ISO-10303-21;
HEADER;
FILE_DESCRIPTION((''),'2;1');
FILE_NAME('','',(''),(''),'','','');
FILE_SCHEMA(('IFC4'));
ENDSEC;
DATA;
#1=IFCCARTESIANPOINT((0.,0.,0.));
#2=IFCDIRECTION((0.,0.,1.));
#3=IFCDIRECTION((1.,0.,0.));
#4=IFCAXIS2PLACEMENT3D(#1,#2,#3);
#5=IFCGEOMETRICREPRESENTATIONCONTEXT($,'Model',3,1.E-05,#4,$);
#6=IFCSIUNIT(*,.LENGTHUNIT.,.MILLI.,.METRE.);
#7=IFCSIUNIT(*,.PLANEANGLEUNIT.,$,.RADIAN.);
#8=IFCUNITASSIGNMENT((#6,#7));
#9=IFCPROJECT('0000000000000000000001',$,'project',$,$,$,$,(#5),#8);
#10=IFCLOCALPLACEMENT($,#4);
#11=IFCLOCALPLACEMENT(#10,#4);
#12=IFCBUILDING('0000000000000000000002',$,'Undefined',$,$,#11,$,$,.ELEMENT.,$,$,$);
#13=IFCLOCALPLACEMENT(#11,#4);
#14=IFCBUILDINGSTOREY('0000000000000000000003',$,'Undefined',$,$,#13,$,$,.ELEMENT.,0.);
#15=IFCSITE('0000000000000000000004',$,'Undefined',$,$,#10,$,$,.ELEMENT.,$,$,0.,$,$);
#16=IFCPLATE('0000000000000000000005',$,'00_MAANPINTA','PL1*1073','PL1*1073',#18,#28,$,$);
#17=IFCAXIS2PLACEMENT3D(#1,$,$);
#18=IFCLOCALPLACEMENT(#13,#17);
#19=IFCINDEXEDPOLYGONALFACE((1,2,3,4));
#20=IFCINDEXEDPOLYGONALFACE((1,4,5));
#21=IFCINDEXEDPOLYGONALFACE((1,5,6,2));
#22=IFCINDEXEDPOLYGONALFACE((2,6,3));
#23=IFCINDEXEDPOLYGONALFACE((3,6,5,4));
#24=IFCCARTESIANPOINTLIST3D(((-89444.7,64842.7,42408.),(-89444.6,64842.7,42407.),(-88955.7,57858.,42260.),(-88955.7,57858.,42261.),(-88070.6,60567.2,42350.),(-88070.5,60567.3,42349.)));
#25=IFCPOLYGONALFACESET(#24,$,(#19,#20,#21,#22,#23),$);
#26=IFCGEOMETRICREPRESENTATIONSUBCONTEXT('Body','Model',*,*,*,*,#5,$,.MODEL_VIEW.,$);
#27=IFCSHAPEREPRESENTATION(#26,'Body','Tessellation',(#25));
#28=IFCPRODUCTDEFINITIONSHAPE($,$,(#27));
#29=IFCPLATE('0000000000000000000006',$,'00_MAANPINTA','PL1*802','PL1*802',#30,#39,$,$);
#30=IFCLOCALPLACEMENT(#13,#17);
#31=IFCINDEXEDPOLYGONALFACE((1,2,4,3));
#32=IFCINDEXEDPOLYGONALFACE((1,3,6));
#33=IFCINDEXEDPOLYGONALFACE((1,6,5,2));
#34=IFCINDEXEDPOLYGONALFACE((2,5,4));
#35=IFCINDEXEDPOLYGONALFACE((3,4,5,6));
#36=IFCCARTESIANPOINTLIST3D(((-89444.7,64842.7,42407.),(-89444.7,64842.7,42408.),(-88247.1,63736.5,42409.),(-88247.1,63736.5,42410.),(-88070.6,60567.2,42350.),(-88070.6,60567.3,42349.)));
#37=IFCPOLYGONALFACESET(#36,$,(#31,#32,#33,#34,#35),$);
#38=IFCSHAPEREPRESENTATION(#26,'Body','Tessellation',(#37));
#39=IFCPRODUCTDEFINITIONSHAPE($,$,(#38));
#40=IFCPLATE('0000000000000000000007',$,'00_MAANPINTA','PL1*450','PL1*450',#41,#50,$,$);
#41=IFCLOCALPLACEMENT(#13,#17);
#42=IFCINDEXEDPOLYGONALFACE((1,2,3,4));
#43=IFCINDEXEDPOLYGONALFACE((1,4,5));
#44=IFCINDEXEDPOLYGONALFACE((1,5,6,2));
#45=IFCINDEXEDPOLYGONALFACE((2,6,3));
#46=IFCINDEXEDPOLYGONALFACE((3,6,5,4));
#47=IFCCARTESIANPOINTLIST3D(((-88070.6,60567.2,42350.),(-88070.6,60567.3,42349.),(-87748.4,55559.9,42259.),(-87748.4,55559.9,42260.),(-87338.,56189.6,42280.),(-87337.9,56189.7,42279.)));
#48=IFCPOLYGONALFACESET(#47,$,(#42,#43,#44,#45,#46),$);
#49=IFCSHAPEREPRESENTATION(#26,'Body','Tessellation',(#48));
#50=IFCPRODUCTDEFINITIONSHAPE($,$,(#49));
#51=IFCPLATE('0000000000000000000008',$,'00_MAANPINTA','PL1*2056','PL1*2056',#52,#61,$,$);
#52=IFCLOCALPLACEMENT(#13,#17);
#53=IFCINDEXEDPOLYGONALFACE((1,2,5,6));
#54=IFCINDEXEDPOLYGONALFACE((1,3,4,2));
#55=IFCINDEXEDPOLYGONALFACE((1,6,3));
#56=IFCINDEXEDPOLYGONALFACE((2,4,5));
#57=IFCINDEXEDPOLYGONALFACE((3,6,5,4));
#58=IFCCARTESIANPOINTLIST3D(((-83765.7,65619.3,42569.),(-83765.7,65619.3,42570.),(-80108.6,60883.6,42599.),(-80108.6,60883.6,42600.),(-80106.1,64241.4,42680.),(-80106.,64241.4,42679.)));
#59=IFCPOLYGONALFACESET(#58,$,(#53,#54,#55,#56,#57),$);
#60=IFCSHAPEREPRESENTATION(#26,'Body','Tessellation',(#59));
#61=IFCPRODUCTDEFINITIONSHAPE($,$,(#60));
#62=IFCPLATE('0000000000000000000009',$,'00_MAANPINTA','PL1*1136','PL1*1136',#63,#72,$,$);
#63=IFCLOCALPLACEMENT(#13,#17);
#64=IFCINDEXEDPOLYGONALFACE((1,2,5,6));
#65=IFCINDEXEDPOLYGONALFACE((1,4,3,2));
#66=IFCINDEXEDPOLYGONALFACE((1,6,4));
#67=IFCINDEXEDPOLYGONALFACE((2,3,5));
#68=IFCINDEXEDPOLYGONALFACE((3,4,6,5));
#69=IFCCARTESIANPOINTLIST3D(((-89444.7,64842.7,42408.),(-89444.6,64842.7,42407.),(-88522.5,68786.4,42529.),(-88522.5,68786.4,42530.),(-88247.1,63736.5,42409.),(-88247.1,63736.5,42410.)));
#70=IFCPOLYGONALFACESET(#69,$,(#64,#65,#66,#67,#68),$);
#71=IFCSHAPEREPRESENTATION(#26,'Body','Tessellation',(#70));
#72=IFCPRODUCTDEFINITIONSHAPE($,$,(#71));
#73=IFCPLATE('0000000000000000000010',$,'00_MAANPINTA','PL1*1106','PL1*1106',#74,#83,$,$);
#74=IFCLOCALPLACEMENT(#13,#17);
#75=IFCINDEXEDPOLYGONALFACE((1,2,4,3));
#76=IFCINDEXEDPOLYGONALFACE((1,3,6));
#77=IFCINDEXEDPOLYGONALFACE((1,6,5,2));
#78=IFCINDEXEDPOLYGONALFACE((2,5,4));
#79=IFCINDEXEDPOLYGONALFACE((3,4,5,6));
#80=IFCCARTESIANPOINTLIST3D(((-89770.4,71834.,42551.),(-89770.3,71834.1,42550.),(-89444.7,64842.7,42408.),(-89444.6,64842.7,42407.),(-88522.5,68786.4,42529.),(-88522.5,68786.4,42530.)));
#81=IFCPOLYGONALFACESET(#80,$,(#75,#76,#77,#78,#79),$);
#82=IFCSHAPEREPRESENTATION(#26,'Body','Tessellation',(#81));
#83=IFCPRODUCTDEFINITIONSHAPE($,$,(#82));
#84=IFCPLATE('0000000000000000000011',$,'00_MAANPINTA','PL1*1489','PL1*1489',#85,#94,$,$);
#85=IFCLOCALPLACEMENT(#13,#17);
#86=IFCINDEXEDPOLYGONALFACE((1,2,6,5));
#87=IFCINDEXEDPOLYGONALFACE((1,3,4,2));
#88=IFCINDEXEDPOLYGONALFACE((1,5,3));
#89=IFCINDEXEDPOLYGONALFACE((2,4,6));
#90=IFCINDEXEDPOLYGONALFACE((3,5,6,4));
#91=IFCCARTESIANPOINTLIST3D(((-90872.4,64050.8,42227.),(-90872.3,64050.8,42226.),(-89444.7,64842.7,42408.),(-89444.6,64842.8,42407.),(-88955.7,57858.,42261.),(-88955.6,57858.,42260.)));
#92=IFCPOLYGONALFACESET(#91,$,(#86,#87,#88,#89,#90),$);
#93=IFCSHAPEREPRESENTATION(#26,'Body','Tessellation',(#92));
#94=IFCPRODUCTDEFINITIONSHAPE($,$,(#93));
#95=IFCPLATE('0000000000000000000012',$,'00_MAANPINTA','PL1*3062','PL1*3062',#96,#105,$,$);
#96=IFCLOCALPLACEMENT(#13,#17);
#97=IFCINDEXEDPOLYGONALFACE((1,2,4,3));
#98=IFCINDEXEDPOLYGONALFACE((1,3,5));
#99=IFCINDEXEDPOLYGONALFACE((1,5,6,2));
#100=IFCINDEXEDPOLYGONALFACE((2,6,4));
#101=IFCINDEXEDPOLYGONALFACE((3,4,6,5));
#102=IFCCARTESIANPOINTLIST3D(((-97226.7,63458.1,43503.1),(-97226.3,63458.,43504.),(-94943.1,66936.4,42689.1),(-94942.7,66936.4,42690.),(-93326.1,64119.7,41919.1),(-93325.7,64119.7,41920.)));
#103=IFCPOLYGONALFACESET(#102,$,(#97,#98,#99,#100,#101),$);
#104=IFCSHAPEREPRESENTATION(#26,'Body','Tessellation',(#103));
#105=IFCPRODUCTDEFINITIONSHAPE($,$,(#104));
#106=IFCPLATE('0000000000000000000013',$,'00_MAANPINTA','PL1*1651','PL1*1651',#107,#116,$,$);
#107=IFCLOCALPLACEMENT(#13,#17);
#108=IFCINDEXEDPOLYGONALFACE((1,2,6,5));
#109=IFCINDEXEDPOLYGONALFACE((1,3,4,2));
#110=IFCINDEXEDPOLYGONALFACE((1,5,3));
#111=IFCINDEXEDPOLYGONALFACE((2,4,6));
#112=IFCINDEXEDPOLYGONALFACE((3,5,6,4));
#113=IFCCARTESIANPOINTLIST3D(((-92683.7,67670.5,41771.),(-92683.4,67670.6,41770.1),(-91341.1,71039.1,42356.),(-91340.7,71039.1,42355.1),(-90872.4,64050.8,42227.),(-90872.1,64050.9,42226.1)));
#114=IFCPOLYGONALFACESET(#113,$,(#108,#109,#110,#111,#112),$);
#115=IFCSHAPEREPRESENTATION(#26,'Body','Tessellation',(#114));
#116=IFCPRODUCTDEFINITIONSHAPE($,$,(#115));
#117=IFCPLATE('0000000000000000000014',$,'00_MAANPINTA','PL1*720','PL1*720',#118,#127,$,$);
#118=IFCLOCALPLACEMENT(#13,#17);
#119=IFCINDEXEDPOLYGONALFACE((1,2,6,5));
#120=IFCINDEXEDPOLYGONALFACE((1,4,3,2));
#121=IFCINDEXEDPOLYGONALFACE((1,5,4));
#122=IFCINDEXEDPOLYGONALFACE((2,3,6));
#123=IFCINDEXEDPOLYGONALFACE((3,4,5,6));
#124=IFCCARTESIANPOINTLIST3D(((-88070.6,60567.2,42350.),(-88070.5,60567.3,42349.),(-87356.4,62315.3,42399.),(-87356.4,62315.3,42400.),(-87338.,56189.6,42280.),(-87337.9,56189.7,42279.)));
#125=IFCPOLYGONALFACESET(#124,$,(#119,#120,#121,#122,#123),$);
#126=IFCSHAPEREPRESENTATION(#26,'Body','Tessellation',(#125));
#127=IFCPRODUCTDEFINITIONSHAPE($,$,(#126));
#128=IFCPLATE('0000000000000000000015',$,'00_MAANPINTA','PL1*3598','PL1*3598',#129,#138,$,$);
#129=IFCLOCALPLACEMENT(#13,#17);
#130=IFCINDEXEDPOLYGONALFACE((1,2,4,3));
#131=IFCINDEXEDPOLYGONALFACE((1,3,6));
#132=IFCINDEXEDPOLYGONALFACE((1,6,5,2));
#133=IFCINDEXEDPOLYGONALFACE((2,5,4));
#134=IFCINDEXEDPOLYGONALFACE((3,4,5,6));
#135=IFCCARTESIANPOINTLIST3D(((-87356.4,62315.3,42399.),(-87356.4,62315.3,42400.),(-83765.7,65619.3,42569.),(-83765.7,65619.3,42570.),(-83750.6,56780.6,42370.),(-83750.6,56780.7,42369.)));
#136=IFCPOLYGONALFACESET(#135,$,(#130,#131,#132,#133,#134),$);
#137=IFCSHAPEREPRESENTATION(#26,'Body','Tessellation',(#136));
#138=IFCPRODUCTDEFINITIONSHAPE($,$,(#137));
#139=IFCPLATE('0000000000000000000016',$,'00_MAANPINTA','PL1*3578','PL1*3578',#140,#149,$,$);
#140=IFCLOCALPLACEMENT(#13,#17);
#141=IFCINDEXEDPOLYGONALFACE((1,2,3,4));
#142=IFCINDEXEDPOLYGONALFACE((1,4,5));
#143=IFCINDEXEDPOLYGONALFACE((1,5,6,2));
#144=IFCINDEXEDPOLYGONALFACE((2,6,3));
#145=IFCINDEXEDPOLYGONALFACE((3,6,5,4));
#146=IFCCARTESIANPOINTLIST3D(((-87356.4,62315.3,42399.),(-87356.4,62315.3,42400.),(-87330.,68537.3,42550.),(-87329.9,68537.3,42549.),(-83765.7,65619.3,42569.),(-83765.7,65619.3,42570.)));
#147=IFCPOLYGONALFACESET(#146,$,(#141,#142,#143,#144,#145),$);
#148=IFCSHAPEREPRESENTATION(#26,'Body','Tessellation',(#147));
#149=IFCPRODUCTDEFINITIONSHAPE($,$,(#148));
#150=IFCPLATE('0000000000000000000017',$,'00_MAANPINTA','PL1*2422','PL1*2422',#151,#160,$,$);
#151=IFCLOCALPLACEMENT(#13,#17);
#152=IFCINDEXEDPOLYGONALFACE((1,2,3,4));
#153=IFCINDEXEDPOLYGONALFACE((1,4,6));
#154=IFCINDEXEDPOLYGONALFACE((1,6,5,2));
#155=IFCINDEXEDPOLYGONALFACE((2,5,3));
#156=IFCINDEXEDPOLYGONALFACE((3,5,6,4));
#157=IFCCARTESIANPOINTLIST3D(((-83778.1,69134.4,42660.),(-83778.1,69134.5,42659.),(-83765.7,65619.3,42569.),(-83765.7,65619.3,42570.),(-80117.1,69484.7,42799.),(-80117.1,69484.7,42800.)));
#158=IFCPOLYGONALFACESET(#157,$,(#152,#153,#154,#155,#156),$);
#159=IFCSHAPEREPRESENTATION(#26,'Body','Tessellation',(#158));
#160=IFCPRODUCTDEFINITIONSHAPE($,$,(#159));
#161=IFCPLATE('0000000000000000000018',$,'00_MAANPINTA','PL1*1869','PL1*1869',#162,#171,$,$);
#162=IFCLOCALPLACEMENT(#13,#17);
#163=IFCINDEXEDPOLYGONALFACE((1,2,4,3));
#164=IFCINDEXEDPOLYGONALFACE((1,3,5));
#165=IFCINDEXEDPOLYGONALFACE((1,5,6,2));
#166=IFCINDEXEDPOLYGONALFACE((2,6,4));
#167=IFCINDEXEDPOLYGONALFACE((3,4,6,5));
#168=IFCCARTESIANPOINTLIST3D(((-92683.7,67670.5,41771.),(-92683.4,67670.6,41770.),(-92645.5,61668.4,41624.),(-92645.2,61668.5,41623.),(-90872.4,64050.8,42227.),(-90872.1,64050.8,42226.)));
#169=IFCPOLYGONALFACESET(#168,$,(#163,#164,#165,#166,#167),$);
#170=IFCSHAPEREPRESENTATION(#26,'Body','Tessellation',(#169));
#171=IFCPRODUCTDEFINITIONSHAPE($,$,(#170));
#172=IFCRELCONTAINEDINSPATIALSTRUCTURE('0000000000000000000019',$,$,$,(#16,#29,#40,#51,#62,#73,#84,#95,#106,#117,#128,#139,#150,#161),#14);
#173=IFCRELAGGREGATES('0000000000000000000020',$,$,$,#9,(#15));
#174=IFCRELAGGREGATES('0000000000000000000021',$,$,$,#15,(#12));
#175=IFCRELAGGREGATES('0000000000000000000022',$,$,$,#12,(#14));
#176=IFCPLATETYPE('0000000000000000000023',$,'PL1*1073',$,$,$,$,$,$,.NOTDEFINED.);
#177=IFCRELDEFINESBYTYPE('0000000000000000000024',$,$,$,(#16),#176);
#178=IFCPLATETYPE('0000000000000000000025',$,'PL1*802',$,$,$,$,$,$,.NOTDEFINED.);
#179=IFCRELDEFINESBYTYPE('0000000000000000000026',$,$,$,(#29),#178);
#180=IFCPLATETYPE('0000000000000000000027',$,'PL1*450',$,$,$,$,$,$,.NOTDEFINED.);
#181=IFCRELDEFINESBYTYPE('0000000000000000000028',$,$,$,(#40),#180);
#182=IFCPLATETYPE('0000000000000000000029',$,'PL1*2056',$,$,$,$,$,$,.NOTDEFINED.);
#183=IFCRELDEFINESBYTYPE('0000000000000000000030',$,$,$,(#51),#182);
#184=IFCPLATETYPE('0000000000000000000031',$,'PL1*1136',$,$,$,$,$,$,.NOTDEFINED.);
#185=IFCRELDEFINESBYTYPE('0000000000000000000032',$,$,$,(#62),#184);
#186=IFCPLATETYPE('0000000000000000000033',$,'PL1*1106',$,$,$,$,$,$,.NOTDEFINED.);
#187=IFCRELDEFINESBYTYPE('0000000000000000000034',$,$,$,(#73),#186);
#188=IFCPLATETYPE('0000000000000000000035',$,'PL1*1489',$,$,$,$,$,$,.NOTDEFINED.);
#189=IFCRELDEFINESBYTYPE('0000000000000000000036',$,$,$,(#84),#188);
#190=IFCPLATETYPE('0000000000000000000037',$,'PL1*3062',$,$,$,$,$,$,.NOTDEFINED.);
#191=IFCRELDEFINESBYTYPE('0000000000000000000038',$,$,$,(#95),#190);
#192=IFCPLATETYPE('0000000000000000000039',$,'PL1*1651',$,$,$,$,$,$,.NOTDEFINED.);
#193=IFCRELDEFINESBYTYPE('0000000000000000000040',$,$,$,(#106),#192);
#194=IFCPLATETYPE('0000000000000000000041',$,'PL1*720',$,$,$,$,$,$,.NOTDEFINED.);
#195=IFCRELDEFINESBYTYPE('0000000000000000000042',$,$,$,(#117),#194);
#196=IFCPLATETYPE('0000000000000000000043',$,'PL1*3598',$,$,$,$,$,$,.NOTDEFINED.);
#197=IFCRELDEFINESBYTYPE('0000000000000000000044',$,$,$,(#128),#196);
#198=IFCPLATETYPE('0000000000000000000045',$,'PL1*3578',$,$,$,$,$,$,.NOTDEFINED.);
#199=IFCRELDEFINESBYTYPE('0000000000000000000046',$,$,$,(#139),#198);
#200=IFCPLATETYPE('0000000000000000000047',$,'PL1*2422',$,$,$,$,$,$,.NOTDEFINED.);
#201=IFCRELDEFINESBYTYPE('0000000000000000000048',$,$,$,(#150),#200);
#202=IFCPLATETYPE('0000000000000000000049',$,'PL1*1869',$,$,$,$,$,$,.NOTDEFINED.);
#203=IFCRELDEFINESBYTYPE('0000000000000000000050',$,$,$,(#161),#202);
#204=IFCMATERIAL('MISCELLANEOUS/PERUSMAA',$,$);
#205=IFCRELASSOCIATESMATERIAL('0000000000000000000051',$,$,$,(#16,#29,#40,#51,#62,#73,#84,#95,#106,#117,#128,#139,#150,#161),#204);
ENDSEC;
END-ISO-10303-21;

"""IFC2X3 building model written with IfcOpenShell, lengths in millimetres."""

from ifc_helpers import new_model, si_unit, frame, origin_with_axes, place, context, subcontext, project, spatial, polyline, outline, extrude, material, type_object, element, save


model = new_model("IFC2X3")

# Units and contexts
model_context = context("Model", 3, precision=1e-05, world=origin_with_axes())
body_context = subcontext(model_context, "Body", "Model", "MODEL_VIEW")
ifc_project = project(units=[si_unit("LENGTHUNIT", "METRE", prefix="MILLI"), si_unit("PLANEANGLEUNIT", "RADIAN")], contexts=[model_context])

# Site, building, storey
site_placement = place(None, origin_with_axes())
site = spatial("IfcSite", under=ifc_project, at=site_placement, Name="Undefined", CompositionType="ELEMENT", RefElevation=0.0)
building_placement = place(site_placement, origin_with_axes())
building = spatial("IfcBuilding", under=site, at=building_placement, Name="Undefined", CompositionType="ELEMENT")
storey_placement = place(building_placement, origin_with_axes())
storey = spatial("IfcBuildingStorey", under=building, at=storey_placement, Name="Undefined", CompositionType="ELEMENT", Elevation=0.0)

# Plates
ifc_material = material(Name="MISCELLANEOUS/PERUSMAA")
plate_type_1 = type_object("IfcPlateType", Name="PL1*1073", PredefinedType="NOTDEFINED")
plate_1_placement = place(storey_placement, frame((-88070.6, 60567.2, 42349.5), z_axis=(0.029735, 0.023113, -0.999291), x_axis=(-0.310399, -0.950094, -0.031211)))
element("IfcPlate", 1, at=plate_1_placement, inside=storey, type_object=plate_type_1, material=ifc_material, Name="00_MAANPINTA", Description="PL1*1073", ObjectType="PL1*1073", context=body_context, shape_type="SweptSolid", body=[
    extrude(outline(polyline([(0.0, 0.0), (2851.6, 0.0), (-3637.4, 2634.5), (0.0, 0.0)])), frame((0.0, 0.0, -0.5), z_axis=(0.0, 0.0, 1.0), x_axis=(1.0, 0.0, 0.0)), (0.0, 0.0, 1.0), 1.0),
])
plate_type_2 = type_object("IfcPlateType", Name="PL1*802", PredefinedType="NOTDEFINED")
plate_2_placement = place(storey_placement, frame((-89444.7, 64842.7, 42407.5), z_axis=(0.020189, 0.020049, -0.999595), x_axis=(0.73456, -0.678543, 0.001227)))
element("IfcPlate", 2, at=plate_2_placement, inside=storey, type_object=plate_type_2, material=ifc_material, Name="00_MAANPINTA", Description="PL1*802", ObjectType="PL1*802", context=body_context, shape_type="SweptSolid", body=[
    extrude(outline(polyline([(0.0, 0.0), (1630.3, 0.0), (3910.4, 2209.1), (0.0, 0.0)])), frame((0.0, 0.0, -0.5), z_axis=(0.0, 0.0, 1.0), x_axis=(1.0, 0.0, 0.0)), (0.0, 0.0, 1.0), 1.0),
])
plate_type_3 = type_object("IfcPlateType", Name="PL1*450", PredefinedType="NOTDEFINED")
plate_3_placement = place(storey_placement, frame((-88070.6, 60567.2, 42349.5), z_axis=(0.019245, 0.019205, -0.99963), x_axis=(0.165039, -0.986161, -0.015769)))
element("IfcPlate", 3, at=plate_3_placement, inside=storey, type_object=plate_type_3, material=ifc_material, Name="00_MAANPINTA", Description="PL1*450", ObjectType="PL1*450", context=body_context, shape_type="SweptSolid", body=[
    extrude(outline(polyline([(0.0, 0.0), (4439.0, 0.0), (4992.6, 508.9), (0.0, 0.0)])), frame((0.0, 0.0, -0.5), z_axis=(0.0, 0.0, 1.0), x_axis=(1.0, 0.0, 0.0)), (0.0, 0.0, 1.0), 1.0),
])
plate_type_4 = type_object("IfcPlateType", Name="PL1*2056", PredefinedType="NOTDEFINED")
plate_4_placement = place(storey_placement, frame((-83765.7, 65619.3, 42569.5), z_axis=(0.038976, 0.023771, -0.998957), x_axis=(0.935493, -0.352225, 0.028119)))
element("IfcPlate", 4, at=plate_4_placement, inside=storey, type_object=plate_type_4, material=ifc_material, Name="00_MAANPINTA", Description="PL1*2056", ObjectType="PL1*2056", context=body_context, shape_type="SweptSolid", body=[
    extrude(outline(polyline([(0.0, 0.0), (3912.0, 0.0), (5090.1, 3145.3), (0.0, 0.0)])), frame((0.0, 0.0, -0.5), z_axis=(0.0, 0.0, 1.0), x_axis=(1.0, 0.0, 0.0)), (0.0, 0.0, 1.0), 1.0),
])
plate_type_5 = type_object("IfcPlateType", Name="PL1*1136", PredefinedType="NOTDEFINED")
plate_5_placement = place(storey_placement, frame((-89444.7, 64842.7, 42407.5), z_axis=(0.024858, 0.025104, -0.999376), x_axis=(0.227591, 0.973291, 0.03011)))
element("IfcPlate", 5, at=plate_5_placement, inside=storey, type_object=plate_type_5, material=ifc_material, Name="00_MAANPINTA", Description="PL1*1136", ObjectType="PL1*1136", context=body_context, shape_type="SweptSolid", body=[
    extrude(outline(polyline([(0.0, 0.0), (4051.8, 0.0), (-804.1, 1418.2), (0.0, 0.0)])), frame((0.0, 0.0, -0.5), z_axis=(0.0, 0.0, 1.0), x_axis=(1.0, 0.0, 0.0)), (0.0, 0.0, 1.0), 1.0),
])
plate_type_6 = type_object("IfcPlateType", Name="PL1*1106", PredefinedType="NOTDEFINED")
plate_6_placement = place(storey_placement, frame((-89444.7, 64842.7, 42407.5), z_axis=(0.037344, 0.022174, -0.999056), x_axis=(-0.046527, 0.998708, 0.020428)))
element("IfcPlate", 6, at=plate_6_placement, inside=storey, type_object=plate_type_6, material=ifc_material, Name="00_MAANPINTA", Description="PL1*1106", ObjectType="PL1*1106", context=body_context, shape_type="SweptSolid", body=[
    extrude(outline(polyline([(0.0, 0.0), (7000.4, 0.0), (3898.1, 1105.5), (0.0, 0.0)])), frame((0.0, 0.0, -0.5), z_axis=(0.0, 0.0, 1.0), x_axis=(1.0, 0.0, 0.0)), (0.0, 0.0, 1.0), 1.0),
])
plate_type_7 = type_object("IfcPlateType", Name="PL1*1489", PredefinedType="NOTDEFINED")
plate_7_placement = place(storey_placement, frame((-90872.3, 64050.8, 42226.5), z_axis=(0.110081, 0.028616, -0.993511), x_axis=(0.869161, 0.482098, 0.110189)))
element("IfcPlate", 7, at=plate_7_placement, inside=storey, type_object=plate_type_7, material=ifc_material, Name="00_MAANPINTA", Description="PL1*1489", ObjectType="PL1*1489", context=body_context, shape_type="SweptSolid", body=[
    extrude(outline(polyline([(0.0, 0.0), (1642.6, 0.0), (-1315.9, 6347.8), (0.0, 0.0)])), frame((0.0, 0.0, -0.5), z_axis=(0.0, 0.0, 1.0), x_axis=(1.0, 0.0, 0.0)), (0.0, 0.0, 1.0), 1.0),
])
plate_type_8 = type_object("IfcPlateType", Name="PL1*3062", PredefinedType="NOTDEFINED")
plate_8_placement = place(storey_placement, frame((-93325.9, 64119.7, 41919.5), z_axis=(-0.380968, 0.03388, -0.923967), x_axis=(-0.91528, -0.155262, 0.371693)))
element("IfcPlate", 8, at=plate_8_placement, inside=storey, type_object=plate_type_8, material=ifc_material, Name="00_MAANPINTA", Description="PL1*3062", ObjectType="PL1*3062", context=body_context, shape_type="SweptSolid", body=[
    extrude(outline(polyline([(0.0, 0.0), (4261.6, 0.0), (1328.9, 3061.9), (0.0, 0.0)])), frame((0.0, 0.0, -0.5), z_axis=(0.0, 0.0, 1.0), x_axis=(1.0, 0.0, 0.0)), (0.0, 0.0, 1.0), 1.0),
])
plate_type_9 = type_object("IfcPlateType", Name="PL1*1651", PredefinedType="NOTDEFINED")
plate_9_placement = place(storey_placement, frame((-90872.2, 64050.8, 42226.5), z_axis=(0.315979, 0.038691, -0.947977), x_axis=(-0.444681, 0.888665, -0.111951)))
element("IfcPlate", 9, at=plate_9_placement, inside=storey, type_object=plate_type_9, material=ifc_material, Name="00_MAANPINTA", Description="PL1*1651", ObjectType="PL1*1651", context=body_context, shape_type="SweptSolid", body=[
    extrude(outline(polyline([(0.0, 0.0), (4073.2, 0.0), (6404.2, 2838.7), (0.0, 0.0)])), frame((0.0, 0.0, -0.5), z_axis=(0.0, 0.0, 1.0), x_axis=(1.0, 0.0, 0.0)), (0.0, 0.0, 1.0), 1.0),
])
plate_type_10 = type_object("IfcPlateType", Name="PL1*720", PredefinedType="NOTDEFINED")
plate_10_placement = place(storey_placement, frame((-88070.6, 60567.2, 42349.5), z_axis=(0.021891, 0.019647, -0.999567), x_axis=(0.378077, 0.925396, 0.026469)))
element("IfcPlate", 10, at=plate_10_placement, inside=storey, type_object=plate_type_10, material=ifc_material, Name="00_MAANPINTA", Description="PL1*720", ObjectType="PL1*720", context=body_context, shape_type="SweptSolid", body=[
    extrude(outline(polyline([(0.0, 0.0), (1889.0, 0.0), (-3775.9, 2334.0), (0.0, 0.0)])), frame((0.0, 0.0, -0.5), z_axis=(0.0, 0.0, 1.0), x_axis=(1.0, 0.0, 0.0)), (0.0, 0.0, 1.0), 1.0),
])
plate_type_11 = type_object("IfcPlateType", Name="PL1*3598", PredefinedType="NOTDEFINED")
plate_11_placement = place(storey_placement, frame((-87356.4, 62315.3, 42399.5), z_axis=(0.026466, 0.02266, -0.999393), x_axis=(0.735425, 0.676711, 0.034819)))
element("IfcPlate", 11, at=plate_11_placement, inside=storey, type_object=plate_type_11, material=ifc_material, Name="00_MAANPINTA", Description="PL1*3598", ObjectType="PL1*3598", context=body_context, shape_type="SweptSolid", body=[
    extrude(outline(polyline([(0.0, 0.0), (4882.4, 0.0), (-1094.6, 6514.4), (0.0, 0.0)])), frame((0.0, 0.0, -0.5), z_axis=(0.0, 0.0, 1.0), x_axis=(1.0, 0.0, 0.0)), (0.0, 0.0, 1.0), 1.0),
])
plate_type_12 = type_object("IfcPlateType", Name="PL1*3578", PredefinedType="NOTDEFINED")
plate_12_placement = place(storey_placement, frame((-83765.7, 65619.3, 42569.5), z_axis=(0.025245, 0.023986, -0.999393), x_axis=(-0.735425, -0.676711, -0.034819)))
element("IfcPlate", 12, at=plate_12_placement, inside=storey, type_object=plate_type_12, material=ifc_material, Name="00_MAANPINTA", Description="PL1*3578", ObjectType="PL1*3578", context=body_context, shape_type="SweptSolid", body=[
    extrude(outline(polyline([(0.0, 0.0), (4882.4, 0.0), (647.3, 4560.7), (0.0, 0.0)])), frame((0.0, 0.0, -0.5), z_axis=(0.0, 0.0, 1.0), x_axis=(1.0, 0.0, 0.0)), (0.0, 0.0, 1.0), 1.0),
])
plate_type_13 = type_object("IfcPlateType", Name="PL1*2422", PredefinedType="NOTDEFINED")
plate_13_placement = place(storey_placement, frame((-83765.7, 65619.3, 42569.5), z_axis=(0.035745, 0.025705, -0.99903), x_axis=(-0.003524, 0.999666, 0.025595)))
element("IfcPlate", 13, at=plate_13_placement, inside=storey, type_object=plate_type_13, material=ifc_material, Name="00_MAANPINTA", Description="PL1*2422", ObjectType="PL1*2422", context=body_context, shape_type="SweptSolid", body=[
    extrude(outline(polyline([(0.0, 0.0), (3516.3, 0.0), (3857.1, 3664.6), (0.0, 0.0)])), frame((0.0, 0.0, -0.5), z_axis=(0.0, 0.0, 1.0), x_axis=(1.0, 0.0, 0.0)), (0.0, 0.0, 1.0), 1.0),
])
plate_type_14 = type_object("IfcPlateType", Name="PL1*1869", PredefinedType="NOTDEFINED")
plate_14_placement = place(storey_placement, frame((-92645.4, 61668.4, 41623.5), z_axis=(0.291264, 0.025274, -0.956309), x_axis=(-0.006358, 0.99968, 0.024484)))
element("IfcPlate", 14, at=plate_14_placement, inside=storey, type_object=plate_type_14, material=ifc_material, Name="00_MAANPINTA", Description="PL1*1869", ObjectType="PL1*1869", context=body_context, shape_type="SweptSolid", body=[
    extrude(outline(polyline([(0.0, 0.0), (6004.0, 0.0), (2385.1, 1869.4), (0.0, 0.0)])), frame((0.0, 0.0, -0.5), z_axis=(0.0, 0.0, 1.0), x_axis=(1.0, 0.0, 0.0)), (0.0, 0.0, 1.0), 1.0),
])

save(model, "model.ifc")
